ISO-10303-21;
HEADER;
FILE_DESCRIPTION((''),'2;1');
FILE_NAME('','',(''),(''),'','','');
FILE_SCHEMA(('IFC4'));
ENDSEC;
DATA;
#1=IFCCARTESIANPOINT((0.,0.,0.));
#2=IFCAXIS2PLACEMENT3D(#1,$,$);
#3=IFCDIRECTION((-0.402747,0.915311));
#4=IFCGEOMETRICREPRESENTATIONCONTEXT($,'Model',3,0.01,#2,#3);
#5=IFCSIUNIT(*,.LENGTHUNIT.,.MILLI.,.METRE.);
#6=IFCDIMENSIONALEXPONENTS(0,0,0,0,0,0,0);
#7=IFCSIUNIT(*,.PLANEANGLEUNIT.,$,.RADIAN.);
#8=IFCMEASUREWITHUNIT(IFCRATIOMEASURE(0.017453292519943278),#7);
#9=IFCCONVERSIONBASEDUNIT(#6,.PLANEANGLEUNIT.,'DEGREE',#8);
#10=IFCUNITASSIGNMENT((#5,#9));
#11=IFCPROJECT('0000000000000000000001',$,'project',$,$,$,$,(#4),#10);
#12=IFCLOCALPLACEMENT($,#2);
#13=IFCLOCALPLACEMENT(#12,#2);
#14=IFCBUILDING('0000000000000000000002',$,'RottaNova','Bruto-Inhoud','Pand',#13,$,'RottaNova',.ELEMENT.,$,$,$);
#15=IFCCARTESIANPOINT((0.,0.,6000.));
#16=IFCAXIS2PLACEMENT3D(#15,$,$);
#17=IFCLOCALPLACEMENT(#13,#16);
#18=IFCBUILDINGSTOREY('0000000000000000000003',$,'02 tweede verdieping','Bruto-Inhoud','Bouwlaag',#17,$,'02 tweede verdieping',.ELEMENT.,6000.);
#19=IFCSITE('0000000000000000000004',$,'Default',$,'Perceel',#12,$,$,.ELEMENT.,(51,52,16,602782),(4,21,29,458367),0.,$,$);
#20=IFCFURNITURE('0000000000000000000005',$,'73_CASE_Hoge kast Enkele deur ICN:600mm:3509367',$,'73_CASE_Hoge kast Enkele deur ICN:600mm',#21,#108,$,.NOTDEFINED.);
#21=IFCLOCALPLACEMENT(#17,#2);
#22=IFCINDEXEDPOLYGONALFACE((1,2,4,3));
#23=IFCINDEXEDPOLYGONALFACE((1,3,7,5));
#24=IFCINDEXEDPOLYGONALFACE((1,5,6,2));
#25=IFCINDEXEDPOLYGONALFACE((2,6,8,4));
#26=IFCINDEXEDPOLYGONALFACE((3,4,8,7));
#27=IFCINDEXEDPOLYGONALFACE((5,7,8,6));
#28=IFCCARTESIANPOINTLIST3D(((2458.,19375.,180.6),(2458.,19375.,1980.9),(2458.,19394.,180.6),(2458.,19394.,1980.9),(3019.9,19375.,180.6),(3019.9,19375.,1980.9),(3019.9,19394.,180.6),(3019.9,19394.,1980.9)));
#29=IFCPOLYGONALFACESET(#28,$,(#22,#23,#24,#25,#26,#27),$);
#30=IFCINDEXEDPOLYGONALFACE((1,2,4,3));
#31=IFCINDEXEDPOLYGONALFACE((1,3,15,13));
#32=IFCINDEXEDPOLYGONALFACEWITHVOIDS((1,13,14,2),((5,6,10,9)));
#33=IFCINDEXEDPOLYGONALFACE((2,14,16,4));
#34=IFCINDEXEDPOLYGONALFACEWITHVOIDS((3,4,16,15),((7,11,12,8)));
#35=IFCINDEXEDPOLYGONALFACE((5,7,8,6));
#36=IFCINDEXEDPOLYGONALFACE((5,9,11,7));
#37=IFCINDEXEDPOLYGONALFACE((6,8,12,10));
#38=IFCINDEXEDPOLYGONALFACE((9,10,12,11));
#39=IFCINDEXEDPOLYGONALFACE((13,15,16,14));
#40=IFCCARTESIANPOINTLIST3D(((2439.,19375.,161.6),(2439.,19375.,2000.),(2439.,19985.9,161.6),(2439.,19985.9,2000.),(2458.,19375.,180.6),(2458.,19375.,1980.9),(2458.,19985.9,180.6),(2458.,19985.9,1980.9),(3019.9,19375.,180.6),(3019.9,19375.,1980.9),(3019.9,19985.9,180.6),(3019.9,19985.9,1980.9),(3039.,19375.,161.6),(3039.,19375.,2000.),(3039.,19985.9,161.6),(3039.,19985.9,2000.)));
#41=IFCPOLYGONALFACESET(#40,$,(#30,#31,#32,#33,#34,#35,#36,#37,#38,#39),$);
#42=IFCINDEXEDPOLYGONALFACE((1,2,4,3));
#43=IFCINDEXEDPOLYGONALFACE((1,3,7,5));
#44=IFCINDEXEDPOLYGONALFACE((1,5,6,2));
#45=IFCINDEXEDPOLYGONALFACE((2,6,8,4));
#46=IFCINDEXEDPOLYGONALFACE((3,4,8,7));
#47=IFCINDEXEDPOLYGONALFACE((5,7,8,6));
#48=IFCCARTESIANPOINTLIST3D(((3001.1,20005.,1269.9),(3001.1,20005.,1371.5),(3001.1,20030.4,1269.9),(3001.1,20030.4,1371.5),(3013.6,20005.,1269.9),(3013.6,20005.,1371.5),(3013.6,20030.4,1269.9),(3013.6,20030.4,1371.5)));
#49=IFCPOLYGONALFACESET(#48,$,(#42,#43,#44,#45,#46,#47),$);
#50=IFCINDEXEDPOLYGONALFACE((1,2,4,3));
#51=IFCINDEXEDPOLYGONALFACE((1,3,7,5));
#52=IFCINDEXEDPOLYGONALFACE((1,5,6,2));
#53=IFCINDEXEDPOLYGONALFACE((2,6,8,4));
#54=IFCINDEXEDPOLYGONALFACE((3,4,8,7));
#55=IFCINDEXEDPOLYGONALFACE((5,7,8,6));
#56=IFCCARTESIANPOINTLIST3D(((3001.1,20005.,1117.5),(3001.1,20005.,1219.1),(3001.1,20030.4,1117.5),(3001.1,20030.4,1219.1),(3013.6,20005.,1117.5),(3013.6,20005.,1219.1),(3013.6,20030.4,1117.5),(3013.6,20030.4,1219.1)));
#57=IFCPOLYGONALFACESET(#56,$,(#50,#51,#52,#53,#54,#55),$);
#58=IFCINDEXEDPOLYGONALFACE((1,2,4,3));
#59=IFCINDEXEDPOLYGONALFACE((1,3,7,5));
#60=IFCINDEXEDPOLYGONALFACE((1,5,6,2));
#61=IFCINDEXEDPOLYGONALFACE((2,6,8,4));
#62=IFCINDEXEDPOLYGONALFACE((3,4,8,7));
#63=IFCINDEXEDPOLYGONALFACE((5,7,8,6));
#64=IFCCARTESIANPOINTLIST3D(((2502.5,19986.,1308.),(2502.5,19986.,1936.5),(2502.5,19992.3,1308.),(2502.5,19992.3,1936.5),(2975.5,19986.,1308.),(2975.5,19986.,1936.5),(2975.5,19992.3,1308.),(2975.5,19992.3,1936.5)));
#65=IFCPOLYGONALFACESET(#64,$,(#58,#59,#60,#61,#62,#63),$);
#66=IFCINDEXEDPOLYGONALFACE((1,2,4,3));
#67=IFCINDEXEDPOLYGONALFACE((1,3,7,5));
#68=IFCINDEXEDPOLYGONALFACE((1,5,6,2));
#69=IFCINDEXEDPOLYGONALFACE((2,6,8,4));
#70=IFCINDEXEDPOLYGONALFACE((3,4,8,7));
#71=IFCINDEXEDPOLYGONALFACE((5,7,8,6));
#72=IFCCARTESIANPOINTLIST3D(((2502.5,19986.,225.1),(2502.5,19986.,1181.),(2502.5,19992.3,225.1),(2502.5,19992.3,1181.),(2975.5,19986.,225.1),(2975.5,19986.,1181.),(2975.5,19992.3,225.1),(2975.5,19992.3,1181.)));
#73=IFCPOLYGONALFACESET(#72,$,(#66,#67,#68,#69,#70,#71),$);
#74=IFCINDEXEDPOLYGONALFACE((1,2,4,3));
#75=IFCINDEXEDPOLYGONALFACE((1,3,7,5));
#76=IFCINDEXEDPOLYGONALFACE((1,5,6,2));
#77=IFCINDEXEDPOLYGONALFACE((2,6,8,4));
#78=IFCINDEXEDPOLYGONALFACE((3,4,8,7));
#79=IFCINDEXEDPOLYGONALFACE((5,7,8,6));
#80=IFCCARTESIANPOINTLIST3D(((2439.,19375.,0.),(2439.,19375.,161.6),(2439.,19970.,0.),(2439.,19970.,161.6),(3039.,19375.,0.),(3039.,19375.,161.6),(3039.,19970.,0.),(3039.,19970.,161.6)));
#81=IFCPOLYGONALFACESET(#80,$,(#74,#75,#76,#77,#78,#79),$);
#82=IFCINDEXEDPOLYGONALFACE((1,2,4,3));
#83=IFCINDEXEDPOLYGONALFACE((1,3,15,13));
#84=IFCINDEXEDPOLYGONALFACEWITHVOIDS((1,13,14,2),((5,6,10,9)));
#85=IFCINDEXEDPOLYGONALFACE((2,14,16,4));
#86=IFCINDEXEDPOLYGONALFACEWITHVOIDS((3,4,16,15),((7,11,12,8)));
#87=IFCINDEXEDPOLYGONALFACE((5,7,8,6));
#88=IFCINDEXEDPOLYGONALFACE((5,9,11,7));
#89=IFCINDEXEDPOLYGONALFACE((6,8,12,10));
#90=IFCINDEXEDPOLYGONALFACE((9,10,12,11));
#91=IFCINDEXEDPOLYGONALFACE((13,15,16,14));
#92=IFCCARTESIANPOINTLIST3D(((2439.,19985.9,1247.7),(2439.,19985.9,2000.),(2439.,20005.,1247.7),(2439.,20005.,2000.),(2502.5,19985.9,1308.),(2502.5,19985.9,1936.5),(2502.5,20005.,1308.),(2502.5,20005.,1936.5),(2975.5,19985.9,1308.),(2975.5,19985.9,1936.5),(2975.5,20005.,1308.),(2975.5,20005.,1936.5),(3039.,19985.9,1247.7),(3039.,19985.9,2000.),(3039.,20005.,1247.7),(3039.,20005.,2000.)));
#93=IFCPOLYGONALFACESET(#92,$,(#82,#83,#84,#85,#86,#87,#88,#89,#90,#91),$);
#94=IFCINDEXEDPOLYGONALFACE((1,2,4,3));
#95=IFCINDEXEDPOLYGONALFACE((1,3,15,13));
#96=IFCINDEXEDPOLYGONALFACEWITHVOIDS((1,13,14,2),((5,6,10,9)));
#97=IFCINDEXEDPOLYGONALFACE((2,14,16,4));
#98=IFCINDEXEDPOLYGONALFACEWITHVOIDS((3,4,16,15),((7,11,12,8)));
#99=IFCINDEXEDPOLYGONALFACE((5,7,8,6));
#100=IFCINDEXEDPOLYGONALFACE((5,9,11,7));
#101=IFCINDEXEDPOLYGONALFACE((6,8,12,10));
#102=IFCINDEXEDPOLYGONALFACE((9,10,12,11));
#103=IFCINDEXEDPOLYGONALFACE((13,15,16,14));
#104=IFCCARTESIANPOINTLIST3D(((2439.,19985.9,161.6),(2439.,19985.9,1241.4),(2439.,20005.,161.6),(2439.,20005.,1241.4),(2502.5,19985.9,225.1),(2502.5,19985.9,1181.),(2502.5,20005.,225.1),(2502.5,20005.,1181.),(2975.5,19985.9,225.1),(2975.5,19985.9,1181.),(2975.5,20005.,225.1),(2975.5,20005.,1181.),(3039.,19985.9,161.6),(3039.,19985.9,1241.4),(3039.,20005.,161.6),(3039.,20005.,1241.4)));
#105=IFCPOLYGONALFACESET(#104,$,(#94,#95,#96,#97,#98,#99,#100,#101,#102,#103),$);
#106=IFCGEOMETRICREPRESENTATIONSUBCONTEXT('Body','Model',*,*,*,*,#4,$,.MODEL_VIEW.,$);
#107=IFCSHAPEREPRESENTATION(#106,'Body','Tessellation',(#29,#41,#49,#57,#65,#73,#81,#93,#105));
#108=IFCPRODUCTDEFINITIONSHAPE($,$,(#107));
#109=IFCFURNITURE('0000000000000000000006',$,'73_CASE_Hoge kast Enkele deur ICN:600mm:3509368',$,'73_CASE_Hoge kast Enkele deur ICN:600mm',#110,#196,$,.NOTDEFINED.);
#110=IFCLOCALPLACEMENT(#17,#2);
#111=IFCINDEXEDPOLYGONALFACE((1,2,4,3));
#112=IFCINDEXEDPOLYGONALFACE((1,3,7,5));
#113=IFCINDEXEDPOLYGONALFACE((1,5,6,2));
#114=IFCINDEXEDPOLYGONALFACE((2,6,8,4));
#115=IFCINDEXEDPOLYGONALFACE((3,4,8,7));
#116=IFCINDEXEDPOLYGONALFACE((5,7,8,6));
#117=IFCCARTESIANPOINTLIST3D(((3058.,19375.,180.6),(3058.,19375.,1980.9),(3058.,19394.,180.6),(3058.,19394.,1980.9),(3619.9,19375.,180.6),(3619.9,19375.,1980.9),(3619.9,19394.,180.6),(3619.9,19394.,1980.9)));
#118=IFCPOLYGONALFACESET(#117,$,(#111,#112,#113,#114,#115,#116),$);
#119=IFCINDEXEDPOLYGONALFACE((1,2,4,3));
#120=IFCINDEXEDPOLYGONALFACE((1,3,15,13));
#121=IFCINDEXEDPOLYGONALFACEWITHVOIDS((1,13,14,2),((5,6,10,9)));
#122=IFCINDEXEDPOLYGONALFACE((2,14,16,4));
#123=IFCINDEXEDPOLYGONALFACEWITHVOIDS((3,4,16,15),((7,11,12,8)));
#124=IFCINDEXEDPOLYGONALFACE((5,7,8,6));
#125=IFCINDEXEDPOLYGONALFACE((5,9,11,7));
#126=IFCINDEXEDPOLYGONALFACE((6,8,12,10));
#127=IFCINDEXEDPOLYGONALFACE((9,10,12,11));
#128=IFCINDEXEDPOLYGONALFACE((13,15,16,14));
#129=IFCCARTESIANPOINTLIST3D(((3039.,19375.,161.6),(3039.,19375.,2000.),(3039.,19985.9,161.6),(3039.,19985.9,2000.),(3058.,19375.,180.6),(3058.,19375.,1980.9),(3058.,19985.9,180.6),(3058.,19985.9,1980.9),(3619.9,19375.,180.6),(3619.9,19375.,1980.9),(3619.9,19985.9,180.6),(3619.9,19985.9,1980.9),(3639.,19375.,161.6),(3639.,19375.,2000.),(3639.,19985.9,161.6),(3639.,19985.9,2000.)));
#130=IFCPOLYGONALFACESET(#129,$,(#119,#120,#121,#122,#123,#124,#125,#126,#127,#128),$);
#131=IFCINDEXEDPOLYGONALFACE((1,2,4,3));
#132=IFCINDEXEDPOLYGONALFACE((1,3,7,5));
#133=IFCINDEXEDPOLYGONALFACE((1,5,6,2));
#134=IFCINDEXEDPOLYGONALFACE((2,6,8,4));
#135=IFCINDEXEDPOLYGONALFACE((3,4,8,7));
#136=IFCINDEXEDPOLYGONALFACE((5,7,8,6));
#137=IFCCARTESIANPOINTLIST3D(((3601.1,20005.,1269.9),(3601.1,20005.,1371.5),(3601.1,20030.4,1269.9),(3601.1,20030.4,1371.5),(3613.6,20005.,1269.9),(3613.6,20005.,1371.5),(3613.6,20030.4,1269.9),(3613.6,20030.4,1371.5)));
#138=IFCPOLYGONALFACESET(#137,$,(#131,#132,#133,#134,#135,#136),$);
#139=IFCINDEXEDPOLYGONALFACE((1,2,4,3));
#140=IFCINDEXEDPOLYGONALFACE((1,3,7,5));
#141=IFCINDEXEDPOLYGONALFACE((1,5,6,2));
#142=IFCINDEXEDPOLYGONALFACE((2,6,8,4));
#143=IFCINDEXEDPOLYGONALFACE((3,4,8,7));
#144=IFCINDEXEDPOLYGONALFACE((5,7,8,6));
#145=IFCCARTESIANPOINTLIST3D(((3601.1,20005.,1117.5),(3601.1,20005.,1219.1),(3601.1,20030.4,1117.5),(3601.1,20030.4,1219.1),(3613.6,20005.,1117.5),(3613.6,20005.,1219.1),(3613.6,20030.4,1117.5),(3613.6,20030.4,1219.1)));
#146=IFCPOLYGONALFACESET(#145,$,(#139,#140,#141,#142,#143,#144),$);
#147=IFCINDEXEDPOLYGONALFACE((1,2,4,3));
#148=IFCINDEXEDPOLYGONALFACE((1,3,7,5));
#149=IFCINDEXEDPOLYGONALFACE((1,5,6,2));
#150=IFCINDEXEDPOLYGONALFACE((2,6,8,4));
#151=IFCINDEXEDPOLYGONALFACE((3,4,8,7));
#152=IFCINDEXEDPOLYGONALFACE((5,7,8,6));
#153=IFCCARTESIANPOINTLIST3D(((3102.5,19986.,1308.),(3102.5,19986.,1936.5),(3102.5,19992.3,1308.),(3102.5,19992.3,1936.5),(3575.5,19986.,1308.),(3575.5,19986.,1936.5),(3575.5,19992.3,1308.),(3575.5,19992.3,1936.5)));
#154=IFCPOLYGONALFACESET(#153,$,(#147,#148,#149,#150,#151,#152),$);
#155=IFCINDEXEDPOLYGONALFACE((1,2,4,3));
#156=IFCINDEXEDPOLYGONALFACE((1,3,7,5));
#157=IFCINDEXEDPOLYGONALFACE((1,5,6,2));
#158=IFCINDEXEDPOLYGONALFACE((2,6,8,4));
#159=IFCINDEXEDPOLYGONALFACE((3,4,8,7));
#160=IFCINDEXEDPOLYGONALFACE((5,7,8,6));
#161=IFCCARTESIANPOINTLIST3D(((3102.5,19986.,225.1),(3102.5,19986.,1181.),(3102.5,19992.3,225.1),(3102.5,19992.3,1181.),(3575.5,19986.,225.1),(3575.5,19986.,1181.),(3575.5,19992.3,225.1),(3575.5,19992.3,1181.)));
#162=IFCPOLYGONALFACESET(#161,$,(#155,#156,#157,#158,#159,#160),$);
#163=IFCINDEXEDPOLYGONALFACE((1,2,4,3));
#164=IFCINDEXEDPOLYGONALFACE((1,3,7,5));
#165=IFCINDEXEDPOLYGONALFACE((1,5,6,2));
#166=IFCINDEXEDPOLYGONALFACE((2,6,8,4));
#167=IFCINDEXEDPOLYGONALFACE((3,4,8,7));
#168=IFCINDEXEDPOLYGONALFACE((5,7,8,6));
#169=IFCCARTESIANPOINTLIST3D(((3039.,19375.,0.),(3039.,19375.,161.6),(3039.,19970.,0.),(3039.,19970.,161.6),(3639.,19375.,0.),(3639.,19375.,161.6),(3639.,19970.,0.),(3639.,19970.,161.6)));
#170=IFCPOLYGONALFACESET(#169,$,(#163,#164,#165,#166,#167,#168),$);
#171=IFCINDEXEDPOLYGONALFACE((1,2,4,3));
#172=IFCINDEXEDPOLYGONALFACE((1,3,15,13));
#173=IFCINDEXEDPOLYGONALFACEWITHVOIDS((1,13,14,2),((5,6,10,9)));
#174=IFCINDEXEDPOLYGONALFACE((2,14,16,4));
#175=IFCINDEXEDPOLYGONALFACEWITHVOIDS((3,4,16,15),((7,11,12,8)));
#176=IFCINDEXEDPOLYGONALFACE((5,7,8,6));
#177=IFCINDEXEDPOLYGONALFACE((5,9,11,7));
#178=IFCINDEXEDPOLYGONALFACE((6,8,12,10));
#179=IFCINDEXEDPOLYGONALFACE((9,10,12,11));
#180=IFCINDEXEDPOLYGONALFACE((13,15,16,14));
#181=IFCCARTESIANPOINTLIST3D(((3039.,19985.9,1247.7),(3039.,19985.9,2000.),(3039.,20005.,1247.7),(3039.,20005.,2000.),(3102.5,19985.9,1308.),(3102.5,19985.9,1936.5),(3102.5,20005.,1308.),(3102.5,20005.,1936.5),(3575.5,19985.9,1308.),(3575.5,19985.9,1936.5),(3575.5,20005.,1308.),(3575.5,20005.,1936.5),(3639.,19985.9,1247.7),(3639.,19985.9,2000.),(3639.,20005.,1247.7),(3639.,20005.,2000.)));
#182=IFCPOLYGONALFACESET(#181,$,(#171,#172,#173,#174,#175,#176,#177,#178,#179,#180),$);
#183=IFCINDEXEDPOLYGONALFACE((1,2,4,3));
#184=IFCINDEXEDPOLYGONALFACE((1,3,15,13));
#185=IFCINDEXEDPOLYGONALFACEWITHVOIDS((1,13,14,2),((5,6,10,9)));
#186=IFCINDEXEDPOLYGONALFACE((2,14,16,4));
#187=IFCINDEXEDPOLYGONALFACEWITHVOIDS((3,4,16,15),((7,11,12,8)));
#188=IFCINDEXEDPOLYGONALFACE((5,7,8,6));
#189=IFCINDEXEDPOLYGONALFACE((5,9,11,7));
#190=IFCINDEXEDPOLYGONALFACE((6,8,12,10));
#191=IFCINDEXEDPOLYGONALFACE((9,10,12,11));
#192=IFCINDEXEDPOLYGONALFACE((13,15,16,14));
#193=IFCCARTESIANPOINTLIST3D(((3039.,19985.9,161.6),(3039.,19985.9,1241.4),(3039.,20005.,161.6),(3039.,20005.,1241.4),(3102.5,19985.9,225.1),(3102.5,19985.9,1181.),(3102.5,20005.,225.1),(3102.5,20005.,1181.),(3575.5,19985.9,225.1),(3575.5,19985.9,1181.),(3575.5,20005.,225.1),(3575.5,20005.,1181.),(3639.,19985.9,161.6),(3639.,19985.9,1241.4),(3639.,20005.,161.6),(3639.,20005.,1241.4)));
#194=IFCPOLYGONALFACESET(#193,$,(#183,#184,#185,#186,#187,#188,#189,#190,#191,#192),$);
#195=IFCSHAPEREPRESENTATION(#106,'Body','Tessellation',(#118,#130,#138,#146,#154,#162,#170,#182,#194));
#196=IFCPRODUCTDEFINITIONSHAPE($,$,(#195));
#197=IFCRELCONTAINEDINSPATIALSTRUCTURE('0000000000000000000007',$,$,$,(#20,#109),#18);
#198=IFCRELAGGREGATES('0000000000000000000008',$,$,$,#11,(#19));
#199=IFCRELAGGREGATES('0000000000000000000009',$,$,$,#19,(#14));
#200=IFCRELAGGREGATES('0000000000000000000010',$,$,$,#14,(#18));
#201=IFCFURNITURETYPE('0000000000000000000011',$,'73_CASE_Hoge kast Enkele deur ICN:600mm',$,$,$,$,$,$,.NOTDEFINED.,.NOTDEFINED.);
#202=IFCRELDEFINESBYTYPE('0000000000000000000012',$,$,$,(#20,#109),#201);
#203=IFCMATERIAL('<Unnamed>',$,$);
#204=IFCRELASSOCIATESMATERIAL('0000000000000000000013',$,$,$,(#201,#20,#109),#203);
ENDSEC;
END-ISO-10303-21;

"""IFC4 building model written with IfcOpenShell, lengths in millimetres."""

from ifc_helpers import new_model, entity, si_unit, converted_unit, direction, frame, frame_2d, origin, origin_2d_with_axis, place, context, subcontext, project, spatial, polyline, rectangle, outline, extrude, source, transform, mapped, material, type_object, type_shapes, element, save


model = new_model("IFC4")

# Units and contexts
model_context = context("Model", 3, precision=0.01, world=origin(), true_north=direction((-0.402747, 0.915311)))
body_context = subcontext(model_context, "Body", "Model", "MODEL_VIEW")
ifc_project = project(units=[si_unit("LENGTHUNIT", "METRE", prefix="MILLI"), converted_unit("PLANEANGLEUNIT", "DEGREE", entity("IfcRatioMeasure", 0.017453292519943278), si_unit("PLANEANGLEUNIT", "RADIAN"), dimensions=[0, 0, 0, 0, 0, 0, 0])], contexts=[model_context])

# Site, building, storey
site_placement = place(None, origin())
site = spatial("IfcSite", under=ifc_project, at=site_placement, Name="Default", ObjectType="Perceel", CompositionType="ELEMENT", RefLatitude=(51, 52, 16, 602782), RefLongitude=(4, 21, 29, 458367), RefElevation=0.0)
building_placement = place(site_placement, origin())
building = spatial("IfcBuilding", under=site, at=building_placement, Name="RottaNova", Description="Bruto-Inhoud", ObjectType="Pand", LongName="RottaNova", CompositionType="ELEMENT")
storey_placement = place(building_placement, frame((0.0, 0.0, 6000.0)))
storey = spatial("IfcBuildingStorey", under=building, at=storey_placement, Name="02 tweede verdieping", Description="Bruto-Inhoud", ObjectType="Bouwlaag", LongName="02 tweede verdieping", CompositionType="ELEMENT", Elevation=6000.0)

# Furniture
ifc_material_1 = material(Name="<Unnamed>")
furniture_type = type_object("IfcFurnitureType", Name="73_CASE_Hoge kast Enkele deur ICN:600mm", AssemblyPlace="NOTDEFINED", PredefinedType="NOTDEFINED", material=ifc_material_1)
shared_shape_1 = source(origin(), body_context, "Body", "SweptSolid", [
    extrude(rectangle(XDim=561.9, YDim=19.1, at=origin_2d_with_axis()), frame((18.7, 9.5, 180.6), z_axis=(0.0, 0.0, 1.0), x_axis=(-1.0, 0.0, 0.0)), (0.0, 0.0, 1.0), 1800.3),
    extrude(outline(polyline([(-300.0, -919.2), (300.0, -919.2), (300.0, 919.2), (-300.0, 919.2), (-300.0, -919.2)]), holes=[polyline([(-280.9, 900.2), (281.0, 900.2), (281.0, -900.2), (-280.9, -900.2), (-280.9, 900.2)])]), frame((18.7, 0.0, 1080.8), z_axis=(0.0, 1.0, 0.0), x_axis=(-1.0, 0.0, 0.0)), (0.0, 0.0, 1.0), 610.9),
    extrude(rectangle(XDim=12.5, YDim=25.4, at=frame_2d((0.0, 0.0), x_axis=(1.0, 0.0))), frame((287.1, 642.7, 1269.9), z_axis=(0.0, 0.0, 1.0), x_axis=(-1.0, 0.0, 0.0)), (0.0, 0.0, 1.0), 101.6),
    extrude(rectangle(XDim=12.5, YDim=25.4, at=frame_2d((0.0, 0.0), x_axis=(1.0, 0.0))), frame((287.1, 642.7, 1117.5), z_axis=(0.0, 0.0, 1.0), x_axis=(-1.0, 0.0, 0.0)), (0.0, 0.0, 1.0), 101.6),
    extrude(rectangle(XDim=473.0, YDim=6.4, at=origin_2d_with_axis()), frame((18.7, 614.1, 1308.0), z_axis=(0.0, 0.0, 1.0), x_axis=(-1.0, 0.0, 0.0)), (0.0, 0.0, 1.0), 628.5),
    extrude(rectangle(XDim=473.0, YDim=6.4, at=origin_2d_with_axis()), frame((18.7, 614.1, 225.1), z_axis=(0.0, 0.0, 1.0), x_axis=(-1.0, 0.0, 0.0)), (0.0, 0.0, 1.0), 956.0),
    extrude(rectangle(XDim=595.0, YDim=600.0, at=frame_2d((0.0, 0.0), x_axis=(1.0, 0.0))), frame((18.7, 297.5, 0.0), z_axis=(0.0, 0.0, 1.0), x_axis=(0.0, 1.0, 0.0)), (0.0, 0.0, 1.0), 161.6),
    extrude(outline(polyline([(-376.1, -300.0), (376.1, -300.0), (376.1, 300.0), (-376.1, 300.0), (-376.1, -300.0)]), holes=[polyline([(-312.6, -236.5), (-312.6, 236.5), (315.8, 236.5), (315.8, -236.5), (-312.6, -236.5)])]), frame((18.7, 610.9, 1623.9), z_axis=(0.0, 1.0, 0.0), x_axis=(0.0, 0.0, -1.0)), (0.0, 0.0, 1.0), 19.1),
    extrude(outline(polyline([(-300.0, -539.9), (300.0, -539.9), (300.0, 539.9), (-300.0, 539.9), (-300.0, -539.9)]), holes=[polyline([(-236.5, 479.6), (236.5, 479.6), (236.5, -476.4), (-236.5, -476.4), (-236.5, 479.6)])]), frame((18.7, 610.9, 701.5), z_axis=(0.0, 1.0, 0.0), x_axis=(-1.0, 0.0, 0.0)), (0.0, 0.0, 1.0), 19.1),
])
type_shapes(furniture_type, [shared_shape_1])
for number, where, name in (
    (1, (2720.3, 19375.0, 0.0), "73_CASE_Hoge kast Enkele deur ICN:600mm:3509367"),
    (2, (3320.3, 19375.0, 0.0), "73_CASE_Hoge kast Enkele deur ICN:600mm:3509368"),
):
    element("IfcFurniture", number, at=place(storey_placement, frame(where)), inside=storey, type_object=furniture_type, material=ifc_material_1, Name=name, ObjectType="73_CASE_Hoge kast Enkele deur ICN:600mm", PredefinedType="NOTDEFINED", context=body_context, shape_type="MappedRepresentation", body=[
        mapped(shared_shape_1, transform((0.0, 0.0, 0.0), scale=1.0)),
    ])

save(model, "model.ifc")
